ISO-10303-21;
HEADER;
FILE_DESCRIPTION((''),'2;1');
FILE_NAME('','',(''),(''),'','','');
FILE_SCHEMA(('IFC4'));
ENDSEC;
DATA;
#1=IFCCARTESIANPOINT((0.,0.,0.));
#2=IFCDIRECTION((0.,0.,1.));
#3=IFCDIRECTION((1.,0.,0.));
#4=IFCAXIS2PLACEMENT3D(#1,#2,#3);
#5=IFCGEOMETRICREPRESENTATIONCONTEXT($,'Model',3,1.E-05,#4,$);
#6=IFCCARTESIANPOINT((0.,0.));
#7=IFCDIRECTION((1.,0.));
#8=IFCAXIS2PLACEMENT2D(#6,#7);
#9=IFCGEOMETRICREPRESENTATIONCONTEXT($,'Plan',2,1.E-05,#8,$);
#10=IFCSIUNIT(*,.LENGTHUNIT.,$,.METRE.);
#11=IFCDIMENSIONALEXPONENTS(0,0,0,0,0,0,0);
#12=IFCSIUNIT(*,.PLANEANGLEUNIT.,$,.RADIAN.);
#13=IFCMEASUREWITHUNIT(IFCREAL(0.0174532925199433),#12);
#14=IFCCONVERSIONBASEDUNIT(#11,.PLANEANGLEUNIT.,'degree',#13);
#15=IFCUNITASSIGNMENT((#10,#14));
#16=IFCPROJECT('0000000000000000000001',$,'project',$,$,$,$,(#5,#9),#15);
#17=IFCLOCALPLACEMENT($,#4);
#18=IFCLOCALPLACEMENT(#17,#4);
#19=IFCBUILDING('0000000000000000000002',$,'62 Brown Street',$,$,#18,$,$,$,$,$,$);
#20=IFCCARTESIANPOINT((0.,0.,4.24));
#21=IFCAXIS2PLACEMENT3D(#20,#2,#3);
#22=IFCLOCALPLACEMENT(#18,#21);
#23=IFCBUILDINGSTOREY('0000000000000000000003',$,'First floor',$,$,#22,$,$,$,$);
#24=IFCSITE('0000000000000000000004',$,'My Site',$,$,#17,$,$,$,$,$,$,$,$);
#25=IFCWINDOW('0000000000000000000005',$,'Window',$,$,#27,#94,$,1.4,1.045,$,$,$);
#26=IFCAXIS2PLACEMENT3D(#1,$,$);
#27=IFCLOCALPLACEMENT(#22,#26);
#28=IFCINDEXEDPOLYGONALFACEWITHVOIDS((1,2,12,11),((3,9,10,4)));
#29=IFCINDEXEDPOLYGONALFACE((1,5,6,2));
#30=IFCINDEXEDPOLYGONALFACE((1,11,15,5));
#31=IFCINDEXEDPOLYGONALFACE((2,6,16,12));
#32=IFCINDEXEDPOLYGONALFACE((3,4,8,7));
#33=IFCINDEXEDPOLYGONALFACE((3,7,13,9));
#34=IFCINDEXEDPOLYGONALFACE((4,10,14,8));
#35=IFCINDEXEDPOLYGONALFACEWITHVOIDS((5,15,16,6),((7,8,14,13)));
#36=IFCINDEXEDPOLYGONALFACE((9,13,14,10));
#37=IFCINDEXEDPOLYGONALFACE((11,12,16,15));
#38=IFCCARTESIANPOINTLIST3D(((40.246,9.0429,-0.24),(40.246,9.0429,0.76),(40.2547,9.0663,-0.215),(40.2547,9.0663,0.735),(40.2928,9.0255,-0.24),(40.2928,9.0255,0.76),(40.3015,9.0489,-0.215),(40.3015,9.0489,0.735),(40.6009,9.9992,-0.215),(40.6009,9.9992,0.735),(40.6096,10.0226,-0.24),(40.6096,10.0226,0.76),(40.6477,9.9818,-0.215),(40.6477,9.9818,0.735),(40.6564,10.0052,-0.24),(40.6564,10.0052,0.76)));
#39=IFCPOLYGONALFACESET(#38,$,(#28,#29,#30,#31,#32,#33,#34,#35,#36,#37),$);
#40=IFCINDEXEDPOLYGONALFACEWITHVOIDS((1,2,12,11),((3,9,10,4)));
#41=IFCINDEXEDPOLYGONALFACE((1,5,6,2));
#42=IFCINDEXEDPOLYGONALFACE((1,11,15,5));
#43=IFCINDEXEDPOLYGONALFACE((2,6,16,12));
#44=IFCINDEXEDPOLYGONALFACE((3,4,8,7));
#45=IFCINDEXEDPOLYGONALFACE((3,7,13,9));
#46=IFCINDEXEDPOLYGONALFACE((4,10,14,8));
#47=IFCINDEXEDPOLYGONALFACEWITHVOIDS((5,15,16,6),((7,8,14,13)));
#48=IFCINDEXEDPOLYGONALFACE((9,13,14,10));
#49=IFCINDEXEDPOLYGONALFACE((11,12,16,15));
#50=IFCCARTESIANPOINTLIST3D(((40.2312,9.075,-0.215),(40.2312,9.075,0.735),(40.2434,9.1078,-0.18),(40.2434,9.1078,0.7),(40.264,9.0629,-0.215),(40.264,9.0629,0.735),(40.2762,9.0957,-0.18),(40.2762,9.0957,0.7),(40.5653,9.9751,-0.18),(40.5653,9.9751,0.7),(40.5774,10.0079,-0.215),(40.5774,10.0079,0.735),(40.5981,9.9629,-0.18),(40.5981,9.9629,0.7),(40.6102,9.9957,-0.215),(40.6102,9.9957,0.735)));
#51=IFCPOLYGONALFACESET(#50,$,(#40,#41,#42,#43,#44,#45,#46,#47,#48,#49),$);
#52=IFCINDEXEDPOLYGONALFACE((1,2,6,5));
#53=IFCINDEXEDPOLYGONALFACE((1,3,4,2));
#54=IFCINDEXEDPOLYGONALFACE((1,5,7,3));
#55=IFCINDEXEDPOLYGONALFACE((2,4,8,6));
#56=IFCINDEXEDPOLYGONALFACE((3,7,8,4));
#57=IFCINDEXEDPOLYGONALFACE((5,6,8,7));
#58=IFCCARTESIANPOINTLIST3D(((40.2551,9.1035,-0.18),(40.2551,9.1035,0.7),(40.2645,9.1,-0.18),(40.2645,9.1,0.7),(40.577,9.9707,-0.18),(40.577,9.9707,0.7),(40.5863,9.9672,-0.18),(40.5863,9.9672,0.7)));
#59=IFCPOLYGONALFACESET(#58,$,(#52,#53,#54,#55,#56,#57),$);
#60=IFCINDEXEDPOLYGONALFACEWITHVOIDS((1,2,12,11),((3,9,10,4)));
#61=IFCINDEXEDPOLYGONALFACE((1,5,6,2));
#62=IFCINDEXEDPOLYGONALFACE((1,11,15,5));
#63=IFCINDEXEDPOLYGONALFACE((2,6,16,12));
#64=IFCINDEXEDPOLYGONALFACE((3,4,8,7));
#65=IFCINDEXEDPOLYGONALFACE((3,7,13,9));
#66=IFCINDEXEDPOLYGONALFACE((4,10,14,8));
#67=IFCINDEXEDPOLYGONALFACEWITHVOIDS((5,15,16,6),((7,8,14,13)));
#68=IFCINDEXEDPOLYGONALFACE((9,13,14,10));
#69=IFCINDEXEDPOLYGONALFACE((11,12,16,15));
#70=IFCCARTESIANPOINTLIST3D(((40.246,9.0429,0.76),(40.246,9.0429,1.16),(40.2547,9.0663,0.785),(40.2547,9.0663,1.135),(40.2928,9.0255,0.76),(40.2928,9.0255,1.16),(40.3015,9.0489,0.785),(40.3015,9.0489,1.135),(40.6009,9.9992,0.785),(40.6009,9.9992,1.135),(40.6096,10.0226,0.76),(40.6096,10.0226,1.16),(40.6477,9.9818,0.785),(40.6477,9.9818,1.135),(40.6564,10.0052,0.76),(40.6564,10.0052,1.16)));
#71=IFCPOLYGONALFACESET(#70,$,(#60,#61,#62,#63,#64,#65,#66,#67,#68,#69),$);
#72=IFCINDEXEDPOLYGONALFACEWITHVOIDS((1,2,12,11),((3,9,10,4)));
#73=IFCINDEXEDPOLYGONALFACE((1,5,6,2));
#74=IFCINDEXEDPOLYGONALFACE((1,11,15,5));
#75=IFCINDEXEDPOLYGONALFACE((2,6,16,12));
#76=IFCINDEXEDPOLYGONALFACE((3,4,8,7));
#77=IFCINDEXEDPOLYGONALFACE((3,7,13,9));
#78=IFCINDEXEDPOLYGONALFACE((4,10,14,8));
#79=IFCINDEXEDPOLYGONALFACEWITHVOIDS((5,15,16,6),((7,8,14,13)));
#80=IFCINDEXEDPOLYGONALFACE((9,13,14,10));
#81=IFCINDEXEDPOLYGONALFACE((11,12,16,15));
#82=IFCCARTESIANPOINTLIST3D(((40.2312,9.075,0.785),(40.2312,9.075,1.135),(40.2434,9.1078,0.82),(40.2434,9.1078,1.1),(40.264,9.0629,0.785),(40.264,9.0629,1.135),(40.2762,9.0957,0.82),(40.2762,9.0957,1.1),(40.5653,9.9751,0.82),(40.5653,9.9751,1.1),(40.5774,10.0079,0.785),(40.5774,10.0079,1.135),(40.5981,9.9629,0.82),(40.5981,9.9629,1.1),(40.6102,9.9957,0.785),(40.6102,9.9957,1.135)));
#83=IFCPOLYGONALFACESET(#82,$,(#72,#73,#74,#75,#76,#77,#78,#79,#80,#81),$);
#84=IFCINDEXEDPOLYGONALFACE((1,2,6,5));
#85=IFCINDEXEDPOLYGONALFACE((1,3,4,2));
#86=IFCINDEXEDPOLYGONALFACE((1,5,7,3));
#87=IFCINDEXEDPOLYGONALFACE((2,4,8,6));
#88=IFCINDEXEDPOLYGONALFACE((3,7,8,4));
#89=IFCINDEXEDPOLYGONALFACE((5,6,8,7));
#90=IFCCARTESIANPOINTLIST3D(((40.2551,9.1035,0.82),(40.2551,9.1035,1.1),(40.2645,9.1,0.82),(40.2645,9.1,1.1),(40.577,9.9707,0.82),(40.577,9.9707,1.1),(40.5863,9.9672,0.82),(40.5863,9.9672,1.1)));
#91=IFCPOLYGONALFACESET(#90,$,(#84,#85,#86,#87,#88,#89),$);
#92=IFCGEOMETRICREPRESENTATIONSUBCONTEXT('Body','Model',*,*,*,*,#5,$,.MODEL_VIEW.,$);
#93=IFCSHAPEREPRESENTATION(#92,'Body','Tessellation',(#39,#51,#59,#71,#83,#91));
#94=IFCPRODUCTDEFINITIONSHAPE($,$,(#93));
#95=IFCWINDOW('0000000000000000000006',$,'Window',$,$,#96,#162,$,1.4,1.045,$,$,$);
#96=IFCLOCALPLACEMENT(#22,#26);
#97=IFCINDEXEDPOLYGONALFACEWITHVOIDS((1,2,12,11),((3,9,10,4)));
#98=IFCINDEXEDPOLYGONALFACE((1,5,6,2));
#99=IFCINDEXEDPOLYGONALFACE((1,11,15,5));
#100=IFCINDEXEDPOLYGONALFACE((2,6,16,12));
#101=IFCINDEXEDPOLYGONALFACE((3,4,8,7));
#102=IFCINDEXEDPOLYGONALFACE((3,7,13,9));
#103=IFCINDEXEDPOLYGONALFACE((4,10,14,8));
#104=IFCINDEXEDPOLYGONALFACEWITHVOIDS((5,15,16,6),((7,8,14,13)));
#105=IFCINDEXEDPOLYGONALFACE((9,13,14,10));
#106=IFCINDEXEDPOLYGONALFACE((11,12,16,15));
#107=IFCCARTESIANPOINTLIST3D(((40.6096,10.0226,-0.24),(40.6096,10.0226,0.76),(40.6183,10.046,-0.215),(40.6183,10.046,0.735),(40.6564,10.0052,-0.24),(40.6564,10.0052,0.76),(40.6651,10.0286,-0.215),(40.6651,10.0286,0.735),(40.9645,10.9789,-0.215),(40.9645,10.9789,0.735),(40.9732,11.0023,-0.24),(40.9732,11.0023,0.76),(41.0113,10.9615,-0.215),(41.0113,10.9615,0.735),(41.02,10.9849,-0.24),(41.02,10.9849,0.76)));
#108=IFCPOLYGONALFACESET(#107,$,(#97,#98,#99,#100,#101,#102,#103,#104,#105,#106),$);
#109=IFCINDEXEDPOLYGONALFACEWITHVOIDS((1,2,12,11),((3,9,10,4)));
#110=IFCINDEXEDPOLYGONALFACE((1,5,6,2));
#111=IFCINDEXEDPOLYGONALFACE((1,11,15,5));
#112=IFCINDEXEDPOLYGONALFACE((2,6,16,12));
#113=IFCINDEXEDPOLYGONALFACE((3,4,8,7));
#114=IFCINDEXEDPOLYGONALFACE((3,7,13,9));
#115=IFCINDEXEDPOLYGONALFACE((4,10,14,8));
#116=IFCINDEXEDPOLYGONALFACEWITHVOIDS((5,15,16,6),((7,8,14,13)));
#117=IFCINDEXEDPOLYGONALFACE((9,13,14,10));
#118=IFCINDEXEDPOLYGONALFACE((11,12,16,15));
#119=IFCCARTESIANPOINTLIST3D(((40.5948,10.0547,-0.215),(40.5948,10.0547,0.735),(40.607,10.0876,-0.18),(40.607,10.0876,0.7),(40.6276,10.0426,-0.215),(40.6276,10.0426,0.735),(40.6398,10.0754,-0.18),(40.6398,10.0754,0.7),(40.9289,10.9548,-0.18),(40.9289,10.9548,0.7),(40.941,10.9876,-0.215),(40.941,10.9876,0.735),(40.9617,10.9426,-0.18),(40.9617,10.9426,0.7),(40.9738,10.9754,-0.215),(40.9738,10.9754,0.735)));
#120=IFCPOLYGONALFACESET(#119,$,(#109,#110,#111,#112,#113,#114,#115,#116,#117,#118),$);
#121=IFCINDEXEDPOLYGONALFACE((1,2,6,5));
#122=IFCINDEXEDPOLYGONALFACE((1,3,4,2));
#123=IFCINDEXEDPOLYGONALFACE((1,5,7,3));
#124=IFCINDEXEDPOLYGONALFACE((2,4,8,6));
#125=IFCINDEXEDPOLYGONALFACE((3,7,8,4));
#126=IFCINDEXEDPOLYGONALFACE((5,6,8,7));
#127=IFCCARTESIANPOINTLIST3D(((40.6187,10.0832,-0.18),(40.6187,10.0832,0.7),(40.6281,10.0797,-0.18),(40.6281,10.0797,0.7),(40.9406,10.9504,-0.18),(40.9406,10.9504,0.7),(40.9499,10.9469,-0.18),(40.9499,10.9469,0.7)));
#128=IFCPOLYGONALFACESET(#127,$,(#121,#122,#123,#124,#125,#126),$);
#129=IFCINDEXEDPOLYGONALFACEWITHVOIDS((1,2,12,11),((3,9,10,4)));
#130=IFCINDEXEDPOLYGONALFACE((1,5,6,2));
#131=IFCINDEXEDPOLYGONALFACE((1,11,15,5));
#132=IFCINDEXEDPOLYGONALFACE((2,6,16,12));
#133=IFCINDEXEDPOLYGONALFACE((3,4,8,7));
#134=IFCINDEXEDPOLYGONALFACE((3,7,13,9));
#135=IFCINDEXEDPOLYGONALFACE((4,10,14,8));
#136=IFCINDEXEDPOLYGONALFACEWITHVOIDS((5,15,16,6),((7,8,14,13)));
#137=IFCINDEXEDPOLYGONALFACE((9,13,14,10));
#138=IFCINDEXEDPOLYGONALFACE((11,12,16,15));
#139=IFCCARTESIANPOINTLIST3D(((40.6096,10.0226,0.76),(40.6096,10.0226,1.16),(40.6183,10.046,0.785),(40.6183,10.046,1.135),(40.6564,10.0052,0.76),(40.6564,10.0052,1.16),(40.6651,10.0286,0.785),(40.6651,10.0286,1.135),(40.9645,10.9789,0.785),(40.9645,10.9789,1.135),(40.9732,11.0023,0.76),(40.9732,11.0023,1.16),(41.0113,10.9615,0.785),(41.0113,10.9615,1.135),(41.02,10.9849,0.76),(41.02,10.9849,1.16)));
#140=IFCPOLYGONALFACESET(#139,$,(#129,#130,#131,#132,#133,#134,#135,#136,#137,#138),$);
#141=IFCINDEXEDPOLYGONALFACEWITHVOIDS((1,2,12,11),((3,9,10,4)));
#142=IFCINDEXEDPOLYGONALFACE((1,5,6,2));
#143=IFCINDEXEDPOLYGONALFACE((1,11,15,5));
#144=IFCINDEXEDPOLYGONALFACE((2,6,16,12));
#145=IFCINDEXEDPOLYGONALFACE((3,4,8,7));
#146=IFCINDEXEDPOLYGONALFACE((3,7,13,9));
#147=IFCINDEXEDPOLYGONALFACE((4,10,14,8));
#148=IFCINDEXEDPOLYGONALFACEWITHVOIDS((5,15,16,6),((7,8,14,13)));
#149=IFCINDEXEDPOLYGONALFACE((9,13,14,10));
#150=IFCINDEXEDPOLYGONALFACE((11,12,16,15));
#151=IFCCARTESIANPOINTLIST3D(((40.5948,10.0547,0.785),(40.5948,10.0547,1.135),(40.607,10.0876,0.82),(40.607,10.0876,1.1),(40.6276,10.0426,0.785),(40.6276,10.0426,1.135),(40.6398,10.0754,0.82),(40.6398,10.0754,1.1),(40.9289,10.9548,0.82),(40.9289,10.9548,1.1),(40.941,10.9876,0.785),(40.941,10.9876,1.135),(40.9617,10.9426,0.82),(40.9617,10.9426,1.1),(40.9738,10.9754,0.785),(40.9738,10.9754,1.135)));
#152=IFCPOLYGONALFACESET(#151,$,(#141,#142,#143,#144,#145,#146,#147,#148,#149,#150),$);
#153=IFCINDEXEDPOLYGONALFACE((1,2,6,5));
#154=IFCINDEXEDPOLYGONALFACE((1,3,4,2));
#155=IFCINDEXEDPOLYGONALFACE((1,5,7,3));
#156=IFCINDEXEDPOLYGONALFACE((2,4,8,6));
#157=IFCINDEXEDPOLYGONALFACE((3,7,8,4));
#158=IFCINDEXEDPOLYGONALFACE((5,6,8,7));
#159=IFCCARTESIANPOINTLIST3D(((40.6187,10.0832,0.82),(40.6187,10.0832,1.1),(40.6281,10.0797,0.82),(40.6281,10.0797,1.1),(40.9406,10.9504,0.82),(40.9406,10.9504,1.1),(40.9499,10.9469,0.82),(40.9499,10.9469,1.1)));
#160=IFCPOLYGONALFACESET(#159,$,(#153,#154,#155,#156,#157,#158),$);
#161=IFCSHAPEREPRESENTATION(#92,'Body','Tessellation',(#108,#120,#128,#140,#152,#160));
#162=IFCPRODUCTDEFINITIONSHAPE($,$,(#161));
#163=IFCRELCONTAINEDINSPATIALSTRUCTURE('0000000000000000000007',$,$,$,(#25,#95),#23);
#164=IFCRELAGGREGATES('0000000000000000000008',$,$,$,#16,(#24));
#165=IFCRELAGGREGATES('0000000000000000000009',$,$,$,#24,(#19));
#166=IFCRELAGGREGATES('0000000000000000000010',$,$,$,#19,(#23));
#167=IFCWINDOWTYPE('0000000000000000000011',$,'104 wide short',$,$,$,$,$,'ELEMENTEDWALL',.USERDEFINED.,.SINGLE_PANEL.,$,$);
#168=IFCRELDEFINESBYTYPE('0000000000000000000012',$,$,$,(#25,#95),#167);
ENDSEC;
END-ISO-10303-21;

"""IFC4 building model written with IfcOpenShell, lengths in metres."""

from ifc_helpers import new_model, entity, si_unit, converted_unit, frame, origin_with_axes, origin_2d_with_axis, place, context, subcontext, project, spatial, line, indexed_curve, outline, extrude, shape, source, transform, mapped, type_object, type_shapes, element, save


model = new_model("IFC4")

# Units and contexts
model_context = context("Model", 3, precision=1e-05, world=origin_with_axes())
plan_context = context("Plan", 2, precision=1e-05, world=origin_2d_with_axis())
body_context_1 = subcontext(model_context, "Body", "Model", "MODEL_VIEW")
body_context_2 = subcontext(plan_context, "Body", "Plan", "PLAN_VIEW")
ifc_project = project(units=[si_unit("LENGTHUNIT", "METRE"), converted_unit("PLANEANGLEUNIT", "degree", entity("IfcReal", 0.0174532925199433), si_unit("PLANEANGLEUNIT", "RADIAN"), dimensions=[0, 0, 0, 0, 0, 0, 0])], contexts=[model_context, plan_context])

# Site, building, storey
site_placement = place(None, origin_with_axes())
site = spatial("IfcSite", under=ifc_project, at=site_placement, Name="My Site")
building_placement = place(site_placement, origin_with_axes())
building = spatial("IfcBuilding", under=site, at=building_placement, Name="62 Brown Street")
storey_placement = place(building_placement, frame((0.0, 0.0, 4.24), z_axis=(0.0, 0.0, 1.0), x_axis=(1.0, 0.0, 0.0)))
storey = spatial("IfcBuildingStorey", under=building, at=storey_placement, Name="First floor")

# Shared definitions
window_type_1 = type_object("IfcWindowType", Name="104 wide short", ElementType="ELEMENTEDWALL", PartitioningType="SINGLE_PANEL", PredefinedType="USERDEFINED")
shared_shape_1 = source(origin_with_axes(), body_context_1, "Body", "SweptSolid", [
    extrude(outline(indexed_curve([(0.0, 0.0), (1.045, 0.0), (1.045, 1.0), (0.0, 1.0)], segments=[line(1, 2, 3, 4, 1)]), holes=[indexed_curve([(0.025, 0.025), (1.02, 0.025), (1.02, 0.975), (0.025, 0.975)], segments=[line(1, 2, 3, 4, 1)])]), frame((0.0, 0.15, 0.0), z_axis=(0.0, -1.0, 0.0), x_axis=(1.0, 0.0, 0.0)), (0.0, 0.0, -1.0), 0.05),
    extrude(outline(indexed_curve([(0.0, 0.0), (0.995, 0.0), (0.995, 0.95), (0.0, 0.95)], segments=[line(1, 2, 3, 4, 1)]), holes=[indexed_curve([(0.035, 0.035), (0.96, 0.035), (0.96, 0.915), (0.035, 0.915)], segments=[line(1, 2, 3, 4, 1)])]), frame((0.025, 0.19, 0.025), z_axis=(0.0, -1.0, 0.0), x_axis=(1.0, 0.0, 0.0)), (0.0, 0.0, -1.0), 0.035),
    extrude(outline(indexed_curve([(0.035, 0.035), (0.96, 0.035), (0.96, 0.915), (0.035, 0.915)], segments=[line(1, 2, 3, 4, 1)])), frame((0.025, 0.2025, 0.025), z_axis=(0.0, -1.0, 0.0), x_axis=(1.0, 0.0, 0.0)), (0.0, 0.0, -1.0), 0.01),
    extrude(outline(indexed_curve([(0.0, 0.0), (1.045, 0.0), (1.045, 0.4), (0.0, 0.4)], segments=[line(1, 2, 3, 4, 1)]), holes=[indexed_curve([(0.025, 0.025), (1.02, 0.025), (1.02, 0.375), (0.025, 0.375)], segments=[line(1, 2, 3, 4, 1)])]), frame((0.0, 0.15, 1.0), z_axis=(0.0, -1.0, 0.0), x_axis=(1.0, 0.0, 0.0)), (0.0, 0.0, -1.0), 0.05),
    extrude(outline(indexed_curve([(0.0, 0.0), (0.995, 0.0), (0.995, 0.35), (0.0, 0.35)], segments=[line(1, 2, 3, 4, 1)]), holes=[indexed_curve([(0.035, 0.035), (0.96, 0.035), (0.96, 0.315), (0.035, 0.315)], segments=[line(1, 2, 3, 4, 1)])]), frame((0.025, 0.19, 1.025), z_axis=(0.0, -1.0, 0.0), x_axis=(1.0, 0.0, 0.0)), (0.0, 0.0, -1.0), 0.035),
    extrude(outline(indexed_curve([(0.035, 0.035), (0.96, 0.035), (0.96, 0.315), (0.035, 0.315)], segments=[line(1, 2, 3, 4, 1)])), frame((0.025, 0.2025, 1.025), z_axis=(0.0, -1.0, 0.0), x_axis=(1.0, 0.0, 0.0)), (0.0, 0.0, -1.0), 0.01),
])
shared_shape_2 = source(origin_with_axes(), body_context_2, "Body", "Curve2D", [
    entity("IfcIndexedPolyCurve", entity("IfcCartesianPointList2D", [[0.025, 0.15], [1.02, 0.15]])),
    entity("IfcIndexedPolyCurve", entity("IfcCartesianPointList2D", [[0.0, 0.2], [0.025, 0.2], [0.025, 0.15], [0.0, 0.15]]), [entity("IfcLineIndex", [1, 2, 3, 4, 1])]),
    entity("IfcIndexedPolyCurve", entity("IfcCartesianPointList2D", [[1.045, 0.2], [1.02, 0.2], [1.02, 0.15], [1.045, 0.15]]), [entity("IfcLineIndex", [1, 2, 3, 4, 1])]),
    entity("IfcIndexedPolyCurve", entity("IfcCartesianPointList2D", [[0.025, 0.19], [0.06, 0.19], [0.06, 0.225], [0.025, 0.225]]), [entity("IfcLineIndex", [1, 2, 3, 4, 1])]),
    entity("IfcIndexedPolyCurve", entity("IfcCartesianPointList2D", [[1.02, 0.19], [0.985, 0.19], [0.985, 0.225], [1.02, 0.225]]), [entity("IfcLineIndex", [1, 2, 3, 4, 1])]),
    entity("IfcIndexedPolyCurve", entity("IfcCartesianPointList2D", [[0.06, 0.19], [0.985, 0.19]])),
    entity("IfcIndexedPolyCurve", entity("IfcCartesianPointList2D", [[0.06, 0.225], [0.985, 0.225]])),
    entity("IfcIndexedPolyCurve", entity("IfcCartesianPointList2D", [[0.06, 0.2075], [0.985, 0.2075]])),
])
type_shapes(window_type_1, [shared_shape_1, shared_shape_2])

# Windows
for number, where, z_axis, x_axis, name in (
    (1, (40.4335, 8.9733, -0.24), (0.0, 0.0, 1.0), (0.347944, 0.937515, 0.0), "Window"),
    (2, (40.7971, 9.953, -0.24), (0.0, 0.0, 1.0), (0.347944, 0.937515, 0.0), "Window"),
):
    element("IfcWindow", number, at=place(storey_placement, frame(where, z_axis=z_axis, x_axis=x_axis)), inside=storey, type_object=window_type_1, Name=name, OverallHeight=1.4, OverallWidth=1.045, shapes=[
        shape(body_context_1, "Body", "MappedRepresentation", [mapped(shared_shape_1, transform((0.0, 0.0, 0.0), x_axis=(1.0, 0.0, 0.0), y_axis=(0.0, 1.0, 0.0), z_axis=(0.0, 0.0, 1.0), scale=1.0))]),
        shape(body_context_2, "Body", "MappedRepresentation", [mapped(shared_shape_2, transform((0.0, 0.0, 0.0), x_axis=(1.0, 0.0, 0.0), y_axis=(0.0, 1.0, 0.0), z_axis=(0.0, 0.0, 1.0), scale=1.0))]),
    ])

save(model, "model.ifc")
